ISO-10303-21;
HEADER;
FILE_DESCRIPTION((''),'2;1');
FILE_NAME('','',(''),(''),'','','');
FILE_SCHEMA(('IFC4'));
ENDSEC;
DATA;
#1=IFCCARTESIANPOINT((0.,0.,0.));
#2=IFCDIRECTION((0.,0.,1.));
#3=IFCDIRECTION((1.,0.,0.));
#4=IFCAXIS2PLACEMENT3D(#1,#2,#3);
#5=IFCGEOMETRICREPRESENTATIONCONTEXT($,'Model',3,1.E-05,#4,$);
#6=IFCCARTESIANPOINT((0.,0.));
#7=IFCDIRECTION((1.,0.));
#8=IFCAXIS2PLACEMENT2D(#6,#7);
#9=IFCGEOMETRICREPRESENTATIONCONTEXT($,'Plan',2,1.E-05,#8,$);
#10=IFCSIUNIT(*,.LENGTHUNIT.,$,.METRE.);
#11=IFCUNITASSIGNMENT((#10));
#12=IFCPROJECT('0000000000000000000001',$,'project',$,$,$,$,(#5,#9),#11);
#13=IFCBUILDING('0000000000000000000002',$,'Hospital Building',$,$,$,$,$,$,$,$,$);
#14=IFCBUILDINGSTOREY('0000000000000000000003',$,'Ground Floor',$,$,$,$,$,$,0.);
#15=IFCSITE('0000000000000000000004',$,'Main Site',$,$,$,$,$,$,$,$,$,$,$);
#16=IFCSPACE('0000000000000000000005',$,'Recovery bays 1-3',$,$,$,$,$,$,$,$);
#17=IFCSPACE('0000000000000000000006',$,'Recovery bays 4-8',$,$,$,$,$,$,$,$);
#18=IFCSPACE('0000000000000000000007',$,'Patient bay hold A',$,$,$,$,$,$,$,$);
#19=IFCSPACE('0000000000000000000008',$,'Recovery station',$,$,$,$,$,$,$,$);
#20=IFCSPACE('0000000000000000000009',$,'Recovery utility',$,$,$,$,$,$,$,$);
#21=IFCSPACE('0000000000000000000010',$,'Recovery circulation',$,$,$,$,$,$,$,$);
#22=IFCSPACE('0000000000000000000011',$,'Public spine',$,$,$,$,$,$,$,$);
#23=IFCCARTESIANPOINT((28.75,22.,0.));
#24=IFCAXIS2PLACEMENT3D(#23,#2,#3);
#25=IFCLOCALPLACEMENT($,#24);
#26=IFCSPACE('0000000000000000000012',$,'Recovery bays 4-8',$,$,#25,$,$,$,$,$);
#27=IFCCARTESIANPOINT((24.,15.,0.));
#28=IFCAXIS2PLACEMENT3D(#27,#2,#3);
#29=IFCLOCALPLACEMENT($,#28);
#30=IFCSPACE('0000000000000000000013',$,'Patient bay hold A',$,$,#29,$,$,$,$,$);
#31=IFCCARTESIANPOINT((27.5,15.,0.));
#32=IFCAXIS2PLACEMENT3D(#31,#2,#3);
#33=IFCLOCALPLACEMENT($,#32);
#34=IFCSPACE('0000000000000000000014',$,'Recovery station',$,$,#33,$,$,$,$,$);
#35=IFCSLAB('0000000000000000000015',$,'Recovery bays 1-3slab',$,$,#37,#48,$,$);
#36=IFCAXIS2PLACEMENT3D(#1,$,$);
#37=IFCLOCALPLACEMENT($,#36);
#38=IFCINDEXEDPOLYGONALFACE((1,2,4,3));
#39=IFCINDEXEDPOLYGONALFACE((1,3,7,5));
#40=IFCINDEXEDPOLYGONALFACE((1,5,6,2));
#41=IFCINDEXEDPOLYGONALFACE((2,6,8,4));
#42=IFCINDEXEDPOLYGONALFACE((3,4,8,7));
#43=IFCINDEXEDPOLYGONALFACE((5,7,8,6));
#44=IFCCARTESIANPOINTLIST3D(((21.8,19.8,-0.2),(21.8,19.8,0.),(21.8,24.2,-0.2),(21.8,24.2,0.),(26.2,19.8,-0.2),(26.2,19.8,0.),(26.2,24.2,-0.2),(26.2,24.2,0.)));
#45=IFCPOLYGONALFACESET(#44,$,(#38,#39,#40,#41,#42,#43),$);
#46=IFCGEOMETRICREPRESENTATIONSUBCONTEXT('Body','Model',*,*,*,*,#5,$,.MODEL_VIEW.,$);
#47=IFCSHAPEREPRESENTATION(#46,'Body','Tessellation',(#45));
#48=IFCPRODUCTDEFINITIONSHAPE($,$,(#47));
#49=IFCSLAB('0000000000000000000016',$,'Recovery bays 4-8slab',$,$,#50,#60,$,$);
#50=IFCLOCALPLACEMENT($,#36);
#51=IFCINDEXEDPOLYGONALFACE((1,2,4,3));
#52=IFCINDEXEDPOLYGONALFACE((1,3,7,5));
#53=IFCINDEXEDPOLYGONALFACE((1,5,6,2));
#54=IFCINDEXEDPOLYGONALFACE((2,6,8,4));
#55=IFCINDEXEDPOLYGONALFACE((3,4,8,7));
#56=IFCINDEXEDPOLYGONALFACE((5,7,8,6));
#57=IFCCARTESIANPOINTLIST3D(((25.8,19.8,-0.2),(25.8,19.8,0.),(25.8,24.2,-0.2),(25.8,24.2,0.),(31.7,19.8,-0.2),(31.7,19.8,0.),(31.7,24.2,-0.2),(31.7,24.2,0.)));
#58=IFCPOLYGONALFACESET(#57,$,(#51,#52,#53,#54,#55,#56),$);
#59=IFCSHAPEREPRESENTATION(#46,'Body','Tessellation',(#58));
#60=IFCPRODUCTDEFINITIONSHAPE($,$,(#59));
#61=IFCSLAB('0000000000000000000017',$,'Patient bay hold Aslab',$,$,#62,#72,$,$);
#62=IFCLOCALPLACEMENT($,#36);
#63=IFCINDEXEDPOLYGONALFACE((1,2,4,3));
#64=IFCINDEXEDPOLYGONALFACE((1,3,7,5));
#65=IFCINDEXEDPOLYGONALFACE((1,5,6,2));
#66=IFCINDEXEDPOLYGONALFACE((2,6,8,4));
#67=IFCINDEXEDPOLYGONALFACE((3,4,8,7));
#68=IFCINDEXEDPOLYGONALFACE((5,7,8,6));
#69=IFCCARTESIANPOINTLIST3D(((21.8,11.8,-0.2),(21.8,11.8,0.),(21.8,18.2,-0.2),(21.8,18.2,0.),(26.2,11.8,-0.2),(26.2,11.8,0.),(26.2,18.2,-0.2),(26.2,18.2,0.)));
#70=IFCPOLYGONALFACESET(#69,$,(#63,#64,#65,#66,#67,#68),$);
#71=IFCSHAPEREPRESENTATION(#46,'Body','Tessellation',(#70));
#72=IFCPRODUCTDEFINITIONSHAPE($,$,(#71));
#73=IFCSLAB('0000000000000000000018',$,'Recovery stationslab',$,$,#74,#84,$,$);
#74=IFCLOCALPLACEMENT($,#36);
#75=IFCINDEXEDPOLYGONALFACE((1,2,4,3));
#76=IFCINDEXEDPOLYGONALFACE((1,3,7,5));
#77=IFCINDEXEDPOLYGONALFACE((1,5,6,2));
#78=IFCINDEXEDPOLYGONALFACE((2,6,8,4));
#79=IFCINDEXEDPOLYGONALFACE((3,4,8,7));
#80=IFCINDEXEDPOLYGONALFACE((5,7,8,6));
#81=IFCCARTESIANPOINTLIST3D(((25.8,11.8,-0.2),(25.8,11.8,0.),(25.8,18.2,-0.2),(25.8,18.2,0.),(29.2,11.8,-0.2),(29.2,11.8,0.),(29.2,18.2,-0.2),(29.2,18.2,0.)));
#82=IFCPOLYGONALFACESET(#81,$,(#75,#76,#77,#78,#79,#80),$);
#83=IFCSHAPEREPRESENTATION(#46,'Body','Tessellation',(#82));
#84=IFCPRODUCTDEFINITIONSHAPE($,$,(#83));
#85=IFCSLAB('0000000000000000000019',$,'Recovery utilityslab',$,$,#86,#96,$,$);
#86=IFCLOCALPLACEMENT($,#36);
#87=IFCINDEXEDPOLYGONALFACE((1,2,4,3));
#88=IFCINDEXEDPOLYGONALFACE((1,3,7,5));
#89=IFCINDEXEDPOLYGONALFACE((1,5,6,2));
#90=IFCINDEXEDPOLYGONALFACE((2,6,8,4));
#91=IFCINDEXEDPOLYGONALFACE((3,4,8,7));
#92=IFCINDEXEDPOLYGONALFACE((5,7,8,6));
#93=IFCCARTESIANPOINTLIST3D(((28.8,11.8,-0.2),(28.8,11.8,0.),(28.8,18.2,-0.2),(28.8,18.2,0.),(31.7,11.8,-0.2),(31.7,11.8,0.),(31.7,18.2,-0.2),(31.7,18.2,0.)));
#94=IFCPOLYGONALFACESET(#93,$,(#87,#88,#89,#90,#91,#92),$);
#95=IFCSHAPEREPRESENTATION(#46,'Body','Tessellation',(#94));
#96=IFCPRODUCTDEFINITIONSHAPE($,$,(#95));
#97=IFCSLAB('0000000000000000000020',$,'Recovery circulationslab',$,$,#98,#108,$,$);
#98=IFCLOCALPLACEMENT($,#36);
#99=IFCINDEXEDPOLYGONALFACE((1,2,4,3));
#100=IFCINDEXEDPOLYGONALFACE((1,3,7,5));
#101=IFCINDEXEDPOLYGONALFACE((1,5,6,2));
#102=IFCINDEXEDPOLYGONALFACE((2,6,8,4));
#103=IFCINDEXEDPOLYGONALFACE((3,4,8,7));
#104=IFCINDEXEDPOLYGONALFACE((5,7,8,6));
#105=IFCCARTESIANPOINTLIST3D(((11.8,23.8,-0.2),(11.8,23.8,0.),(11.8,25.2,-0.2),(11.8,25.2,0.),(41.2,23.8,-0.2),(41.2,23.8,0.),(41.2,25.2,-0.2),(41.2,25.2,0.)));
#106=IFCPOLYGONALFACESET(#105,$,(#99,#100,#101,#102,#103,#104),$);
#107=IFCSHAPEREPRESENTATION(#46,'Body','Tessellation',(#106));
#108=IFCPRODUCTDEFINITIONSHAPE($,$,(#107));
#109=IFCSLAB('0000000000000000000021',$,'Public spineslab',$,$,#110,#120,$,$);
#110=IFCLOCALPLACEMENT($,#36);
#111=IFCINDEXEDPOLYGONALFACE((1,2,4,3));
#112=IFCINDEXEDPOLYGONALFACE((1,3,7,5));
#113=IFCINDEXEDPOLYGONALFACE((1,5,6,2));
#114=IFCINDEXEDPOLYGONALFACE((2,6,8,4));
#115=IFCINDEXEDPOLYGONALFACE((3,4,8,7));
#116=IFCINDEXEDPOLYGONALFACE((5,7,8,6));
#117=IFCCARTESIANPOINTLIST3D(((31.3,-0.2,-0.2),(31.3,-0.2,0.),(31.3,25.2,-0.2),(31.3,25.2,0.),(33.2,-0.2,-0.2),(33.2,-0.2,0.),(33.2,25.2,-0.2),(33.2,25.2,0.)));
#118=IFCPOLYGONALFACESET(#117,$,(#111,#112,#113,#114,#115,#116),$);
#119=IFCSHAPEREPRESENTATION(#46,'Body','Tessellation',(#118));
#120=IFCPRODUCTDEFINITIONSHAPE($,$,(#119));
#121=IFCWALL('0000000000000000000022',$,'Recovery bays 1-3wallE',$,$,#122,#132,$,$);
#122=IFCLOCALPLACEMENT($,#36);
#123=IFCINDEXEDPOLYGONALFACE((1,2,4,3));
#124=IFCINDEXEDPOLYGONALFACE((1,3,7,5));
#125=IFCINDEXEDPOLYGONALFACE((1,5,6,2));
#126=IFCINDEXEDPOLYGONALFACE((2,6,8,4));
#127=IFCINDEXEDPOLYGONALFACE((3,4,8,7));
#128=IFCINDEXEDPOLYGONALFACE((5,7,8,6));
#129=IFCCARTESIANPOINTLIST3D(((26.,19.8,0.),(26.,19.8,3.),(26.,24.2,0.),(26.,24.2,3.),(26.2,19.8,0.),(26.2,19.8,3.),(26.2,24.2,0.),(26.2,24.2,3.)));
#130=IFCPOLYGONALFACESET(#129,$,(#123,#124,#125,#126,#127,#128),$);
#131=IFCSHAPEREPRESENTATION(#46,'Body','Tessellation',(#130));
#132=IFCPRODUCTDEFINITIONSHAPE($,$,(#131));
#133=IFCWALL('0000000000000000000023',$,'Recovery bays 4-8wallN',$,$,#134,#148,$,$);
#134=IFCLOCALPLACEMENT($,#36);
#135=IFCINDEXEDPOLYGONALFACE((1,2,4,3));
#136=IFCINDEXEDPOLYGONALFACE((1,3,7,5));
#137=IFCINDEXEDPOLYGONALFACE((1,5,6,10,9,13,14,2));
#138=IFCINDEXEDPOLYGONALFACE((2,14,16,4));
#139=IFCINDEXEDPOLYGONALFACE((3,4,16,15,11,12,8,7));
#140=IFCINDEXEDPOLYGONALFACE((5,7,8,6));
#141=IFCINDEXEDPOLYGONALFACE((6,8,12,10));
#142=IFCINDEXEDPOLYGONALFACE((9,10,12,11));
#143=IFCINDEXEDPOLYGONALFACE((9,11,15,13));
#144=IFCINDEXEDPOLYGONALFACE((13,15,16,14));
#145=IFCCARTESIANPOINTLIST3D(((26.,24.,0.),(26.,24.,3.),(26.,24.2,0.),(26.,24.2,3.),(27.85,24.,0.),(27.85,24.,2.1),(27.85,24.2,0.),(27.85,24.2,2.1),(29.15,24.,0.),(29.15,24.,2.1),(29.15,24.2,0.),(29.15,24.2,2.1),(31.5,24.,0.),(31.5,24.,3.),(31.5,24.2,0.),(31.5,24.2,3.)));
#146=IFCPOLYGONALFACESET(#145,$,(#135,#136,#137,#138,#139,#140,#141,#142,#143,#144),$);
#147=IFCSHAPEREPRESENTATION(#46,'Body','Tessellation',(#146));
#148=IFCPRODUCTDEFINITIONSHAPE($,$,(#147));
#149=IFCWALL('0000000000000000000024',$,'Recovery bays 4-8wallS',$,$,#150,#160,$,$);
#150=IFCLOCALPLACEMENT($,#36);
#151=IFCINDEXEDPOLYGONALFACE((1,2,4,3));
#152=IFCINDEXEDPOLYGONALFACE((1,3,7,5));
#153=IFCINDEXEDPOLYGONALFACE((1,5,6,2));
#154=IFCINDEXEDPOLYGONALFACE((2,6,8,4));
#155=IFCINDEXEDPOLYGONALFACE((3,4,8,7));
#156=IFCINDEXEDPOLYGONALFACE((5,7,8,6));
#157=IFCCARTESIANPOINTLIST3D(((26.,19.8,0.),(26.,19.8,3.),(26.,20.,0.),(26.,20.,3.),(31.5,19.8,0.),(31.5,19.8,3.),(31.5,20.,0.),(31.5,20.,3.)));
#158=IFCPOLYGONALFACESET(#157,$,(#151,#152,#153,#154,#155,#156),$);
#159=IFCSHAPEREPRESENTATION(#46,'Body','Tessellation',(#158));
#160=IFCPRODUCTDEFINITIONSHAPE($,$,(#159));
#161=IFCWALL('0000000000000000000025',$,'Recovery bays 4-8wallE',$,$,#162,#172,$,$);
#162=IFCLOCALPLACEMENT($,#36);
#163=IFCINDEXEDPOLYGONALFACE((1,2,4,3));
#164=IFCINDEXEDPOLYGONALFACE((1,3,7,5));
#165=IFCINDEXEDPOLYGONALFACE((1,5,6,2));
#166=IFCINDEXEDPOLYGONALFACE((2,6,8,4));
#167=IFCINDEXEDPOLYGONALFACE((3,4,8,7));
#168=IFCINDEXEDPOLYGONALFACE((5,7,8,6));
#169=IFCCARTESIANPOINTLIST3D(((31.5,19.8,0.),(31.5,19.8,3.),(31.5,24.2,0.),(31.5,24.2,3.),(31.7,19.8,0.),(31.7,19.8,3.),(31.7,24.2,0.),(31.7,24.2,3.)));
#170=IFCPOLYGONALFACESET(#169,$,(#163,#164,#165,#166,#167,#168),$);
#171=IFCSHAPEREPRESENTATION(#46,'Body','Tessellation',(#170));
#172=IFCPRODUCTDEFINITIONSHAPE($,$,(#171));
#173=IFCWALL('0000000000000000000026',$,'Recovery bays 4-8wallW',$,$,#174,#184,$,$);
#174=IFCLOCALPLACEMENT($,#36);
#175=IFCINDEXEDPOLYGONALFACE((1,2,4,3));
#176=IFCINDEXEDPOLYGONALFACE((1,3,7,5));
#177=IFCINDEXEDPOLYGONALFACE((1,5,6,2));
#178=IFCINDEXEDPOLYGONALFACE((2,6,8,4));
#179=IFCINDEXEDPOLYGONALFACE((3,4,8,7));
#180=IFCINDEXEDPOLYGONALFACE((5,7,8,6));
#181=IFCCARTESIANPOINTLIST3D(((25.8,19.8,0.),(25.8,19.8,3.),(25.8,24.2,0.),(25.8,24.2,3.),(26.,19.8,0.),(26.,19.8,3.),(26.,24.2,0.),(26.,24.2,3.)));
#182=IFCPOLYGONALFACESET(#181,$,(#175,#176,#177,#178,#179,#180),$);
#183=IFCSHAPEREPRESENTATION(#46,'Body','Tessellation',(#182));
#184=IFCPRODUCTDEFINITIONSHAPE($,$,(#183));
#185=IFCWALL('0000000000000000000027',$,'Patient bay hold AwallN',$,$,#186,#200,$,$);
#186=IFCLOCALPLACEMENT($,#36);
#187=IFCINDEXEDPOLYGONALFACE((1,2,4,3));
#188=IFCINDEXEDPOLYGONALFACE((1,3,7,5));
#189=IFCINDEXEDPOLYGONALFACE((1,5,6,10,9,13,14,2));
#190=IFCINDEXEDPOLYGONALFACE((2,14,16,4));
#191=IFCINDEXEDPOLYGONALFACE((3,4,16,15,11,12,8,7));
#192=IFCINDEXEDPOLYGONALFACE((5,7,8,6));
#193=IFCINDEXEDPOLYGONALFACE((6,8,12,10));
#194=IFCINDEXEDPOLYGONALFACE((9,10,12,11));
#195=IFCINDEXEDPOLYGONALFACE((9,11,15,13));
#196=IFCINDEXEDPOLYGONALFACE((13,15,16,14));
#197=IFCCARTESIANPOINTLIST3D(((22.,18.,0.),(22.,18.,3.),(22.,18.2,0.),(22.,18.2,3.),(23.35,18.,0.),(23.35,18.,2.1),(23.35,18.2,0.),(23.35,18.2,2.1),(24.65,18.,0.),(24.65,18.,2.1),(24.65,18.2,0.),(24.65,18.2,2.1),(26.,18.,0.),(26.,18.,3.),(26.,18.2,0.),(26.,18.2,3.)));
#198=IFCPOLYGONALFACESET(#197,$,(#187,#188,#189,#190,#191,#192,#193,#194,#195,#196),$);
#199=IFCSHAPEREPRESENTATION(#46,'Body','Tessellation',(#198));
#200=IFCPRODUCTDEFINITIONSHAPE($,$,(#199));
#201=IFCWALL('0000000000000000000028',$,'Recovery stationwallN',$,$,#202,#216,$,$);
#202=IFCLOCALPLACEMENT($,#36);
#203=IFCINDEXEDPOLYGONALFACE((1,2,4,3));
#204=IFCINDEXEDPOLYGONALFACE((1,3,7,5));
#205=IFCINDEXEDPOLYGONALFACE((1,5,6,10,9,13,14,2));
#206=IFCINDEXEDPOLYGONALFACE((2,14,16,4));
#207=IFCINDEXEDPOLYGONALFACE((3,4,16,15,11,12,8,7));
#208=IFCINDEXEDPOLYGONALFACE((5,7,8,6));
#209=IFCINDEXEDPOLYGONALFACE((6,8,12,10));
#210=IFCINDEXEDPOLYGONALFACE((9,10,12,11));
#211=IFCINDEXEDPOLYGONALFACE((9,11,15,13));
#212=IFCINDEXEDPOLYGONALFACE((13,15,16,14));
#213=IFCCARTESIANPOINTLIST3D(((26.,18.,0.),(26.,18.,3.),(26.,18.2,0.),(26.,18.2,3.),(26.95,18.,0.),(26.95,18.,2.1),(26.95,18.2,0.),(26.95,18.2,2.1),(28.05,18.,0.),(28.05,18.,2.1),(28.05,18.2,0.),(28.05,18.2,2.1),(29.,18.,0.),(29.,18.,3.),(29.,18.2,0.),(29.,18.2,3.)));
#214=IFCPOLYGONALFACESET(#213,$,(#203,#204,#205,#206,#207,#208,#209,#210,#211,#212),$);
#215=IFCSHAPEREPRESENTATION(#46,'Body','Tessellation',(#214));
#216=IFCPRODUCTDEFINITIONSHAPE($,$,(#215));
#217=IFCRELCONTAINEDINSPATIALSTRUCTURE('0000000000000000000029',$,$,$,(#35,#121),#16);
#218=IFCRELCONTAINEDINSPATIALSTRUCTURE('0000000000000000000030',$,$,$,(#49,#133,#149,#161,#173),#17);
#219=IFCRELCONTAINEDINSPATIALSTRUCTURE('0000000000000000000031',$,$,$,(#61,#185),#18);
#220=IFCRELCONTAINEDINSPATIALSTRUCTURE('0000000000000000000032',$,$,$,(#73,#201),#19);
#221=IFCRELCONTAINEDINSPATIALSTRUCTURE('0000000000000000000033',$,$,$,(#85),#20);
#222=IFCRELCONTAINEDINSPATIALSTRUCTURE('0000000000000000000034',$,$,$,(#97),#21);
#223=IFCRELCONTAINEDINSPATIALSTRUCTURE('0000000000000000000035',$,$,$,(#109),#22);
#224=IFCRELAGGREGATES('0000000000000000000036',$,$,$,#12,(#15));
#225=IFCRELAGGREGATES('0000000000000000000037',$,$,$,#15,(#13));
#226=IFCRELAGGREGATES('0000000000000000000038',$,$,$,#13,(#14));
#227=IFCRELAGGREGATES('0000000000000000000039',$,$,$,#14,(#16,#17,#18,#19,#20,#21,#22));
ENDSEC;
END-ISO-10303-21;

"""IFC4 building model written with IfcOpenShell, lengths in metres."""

from ifc_helpers import new_model, si_unit, frame, origin_with_axes, origin_2d_with_axis, place, context, subcontext, project, spatial, indexed_curve, rectangle, outline, extrude, element, save


model = new_model("IFC4")

# Units and contexts
model_context = context("Model", 3, precision=1e-05, world=origin_with_axes())
plan_context = context("Plan", 2, precision=1e-05, world=origin_2d_with_axis())
body_context = subcontext(model_context, "Body", "Model", "MODEL_VIEW")
ifc_project = project(units=[si_unit("LENGTHUNIT", "METRE")], contexts=[model_context, plan_context])

# Site, building, storey, space
site = spatial("IfcSite", under=ifc_project, Name="Main Site")
building = spatial("IfcBuilding", under=site, Name="Hospital Building")
storey = spatial("IfcBuildingStorey", under=building, Name="Ground Floor", Elevation=0.0)
space_1 = spatial("IfcSpace", under=storey, Name="Recovery bays 1-3")

# Slab
slab_1_placement = place(None, frame((24.0, 22.0, -0.2), z_axis=(0.0, 0.0, 1.0), x_axis=(1.0, 0.0, 0.0)))
element("IfcSlab", 1, at=slab_1_placement, inside=space_1, Name="Recovery bays 1-3slab", context=body_context, shape_type="SweptSolid", body=[
    extrude(rectangle(XDim=4.4, YDim=4.4), origin_with_axes(), (0.0, 0.0, 1.0), 0.2),
])

# Shared definitions
space_2 = spatial("IfcSpace", under=storey, Name="Recovery bays 4-8")

# Slab
slab_2_placement = place(None, frame((28.75, 22.0, -0.2), z_axis=(0.0, 0.0, 1.0), x_axis=(1.0, 0.0, 0.0)))
element("IfcSlab", 2, at=slab_2_placement, inside=space_2, Name="Recovery bays 4-8slab", context=body_context, shape_type="SweptSolid", body=[
    extrude(rectangle(XDim=5.9, YDim=4.4), origin_with_axes(), (0.0, 0.0, 1.0), 0.2),
])

# Shared definitions
space_3 = spatial("IfcSpace", under=storey, Name="Patient bay hold A")

# Slab
slab_3_placement = place(None, frame((24.0, 15.0, -0.2), z_axis=(0.0, 0.0, 1.0), x_axis=(1.0, 0.0, 0.0)))
element("IfcSlab", 3, at=slab_3_placement, inside=space_3, Name="Patient bay hold Aslab", context=body_context, shape_type="SweptSolid", body=[
    extrude(rectangle(XDim=4.4, YDim=6.4), origin_with_axes(), (0.0, 0.0, 1.0), 0.2),
])

# Shared definitions
space_4 = spatial("IfcSpace", under=storey, Name="Recovery station")

# Slab
slab_4_placement = place(None, frame((27.5, 15.0, -0.2), z_axis=(0.0, 0.0, 1.0), x_axis=(1.0, 0.0, 0.0)))
element("IfcSlab", 4, at=slab_4_placement, inside=space_4, Name="Recovery stationslab", context=body_context, shape_type="SweptSolid", body=[
    extrude(rectangle(XDim=3.4, YDim=6.4), origin_with_axes(), (0.0, 0.0, 1.0), 0.2),
])

# Shared definitions
space_5 = spatial("IfcSpace", under=storey, Name="Recovery utility")

# Slab
slab_5_placement = place(None, frame((30.25, 15.0, -0.2), z_axis=(0.0, 0.0, 1.0), x_axis=(1.0, 0.0, 0.0)))
element("IfcSlab", 5, at=slab_5_placement, inside=space_5, Name="Recovery utilityslab", context=body_context, shape_type="SweptSolid", body=[
    extrude(rectangle(XDim=2.9, YDim=6.4), origin_with_axes(), (0.0, 0.0, 1.0), 0.2),
])

# Shared definitions
space_6 = spatial("IfcSpace", under=storey, Name="Recovery circulation")

# Slab
slab_6_placement = place(None, frame((26.5, 24.5, -0.2), z_axis=(0.0, 0.0, 1.0), x_axis=(1.0, 0.0, 0.0)))
element("IfcSlab", 6, at=slab_6_placement, inside=space_6, Name="Recovery circulationslab", context=body_context, shape_type="SweptSolid", body=[
    extrude(rectangle(XDim=29.4, YDim=1.4), origin_with_axes(), (0.0, 0.0, 1.0), 0.2),
])

# Shared definitions
space_7 = spatial("IfcSpace", under=storey, Name="Public spine")

# Slab
slab_7_placement = place(None, frame((32.25, 12.5, -0.2), z_axis=(0.0, 0.0, 1.0), x_axis=(1.0, 0.0, 0.0)))
element("IfcSlab", 7, at=slab_7_placement, inside=space_7, Name="Public spineslab", context=body_context, shape_type="SweptSolid", body=[
    extrude(rectangle(XDim=1.9, YDim=25.4), origin_with_axes(), (0.0, 0.0, 1.0), 0.2),
])

# Walls
wall_1_placement = place(None, frame((26.2, 19.8, 0.0), z_axis=(0.0, 0.0, 1.0), x_axis=(0.0, 1.0, 0.0)))
element("IfcWall", 8, at=wall_1_placement, inside=space_1, Name="Recovery bays 1-3wallE", context=body_context, shape_type="SweptSolid", body=[
    extrude(outline(indexed_curve([(0.0, 0.0), (0.0, 0.2), (4.4, 0.2), (4.4, 0.0), (0.0, 0.0)], self_intersect=False)), origin_with_axes(), (0.0, 0.0, 1.0), 3.0),
])
wall_2_placement = place(None, frame((26.0, 24.0, 0.0), z_axis=(0.0, 0.0, 1.0), x_axis=(1.0, 0.0, 0.0)))
wall_2 = element("IfcWall", 9, at=wall_2_placement, inside=space_2, Name="Recovery bays 4-8wallN", context=body_context, shape_type="SweptSolid", body=[
    extrude(outline(indexed_curve([(0.0, 0.0), (0.0, 0.2), (5.5, 0.2), (5.5, 0.0), (0.0, 0.0)], self_intersect=False)), origin_with_axes(), (0.0, 0.0, 1.0), 3.0),
])

# Shared definitions
space_8_placement = place(None, frame((28.75, 22.0, 0.0), z_axis=(0.0, 0.0, 1.0), x_axis=(1.0, 0.0, 0.0)))
space_8 = spatial("IfcSpace", at=space_8_placement, Name="Recovery bays 4-8")

# Opening
opening_1_placement = place(wall_2_placement, frame((1.85, -0.1, 0.0), z_axis=(0.0, 0.0, 1.0), x_axis=(1.0, 0.0, 0.0)))
element("IfcOpeningElement", 10, at=opening_1_placement, inside=space_8, cuts=wall_2, context=body_context, shape_type="SweptSolid", body=[
    extrude(outline(indexed_curve([(0.0, 0.0), (0.0, 0.4), (1.3, 0.4), (1.3, 0.0), (0.0, 0.0)], self_intersect=False)), origin_with_axes(), (0.0, 0.0, 1.0), 2.1),
])

# Walls
wall_3_placement = place(None, frame((26.0, 19.8, 0.0), z_axis=(0.0, 0.0, 1.0), x_axis=(1.0, 0.0, 0.0)))
element("IfcWall", 11, at=wall_3_placement, inside=space_2, Name="Recovery bays 4-8wallS", context=body_context, shape_type="SweptSolid", body=[
    extrude(outline(indexed_curve([(0.0, 0.0), (0.0, 0.2), (5.5, 0.2), (5.5, 0.0), (0.0, 0.0)], self_intersect=False)), origin_with_axes(), (0.0, 0.0, 1.0), 3.0),
])
for number, where, z_axis, x_axis, name in (
    (12, (31.7, 19.8, 0.0), (0.0, 0.0, 1.0), (0.0, 1.0, 0.0), "Recovery bays 4-8wallE"),
    (13, (26.0, 19.8, 0.0), (0.0, 0.0, 1.0), (0.0, 1.0, 0.0), "Recovery bays 4-8wallW"),
):
    element("IfcWall", number, at=place(None, frame(where, z_axis=z_axis, x_axis=x_axis)), inside=space_2, Name=name, context=body_context, shape_type="SweptSolid", body=[
        extrude(outline(indexed_curve([(0.0, 0.0), (0.0, 0.2), (4.4, 0.2), (4.4, 0.0), (0.0, 0.0)], self_intersect=False)), origin_with_axes(), (0.0, 0.0, 1.0), 3.0),
    ])

# Wall
wall_4_placement = place(None, frame((22.0, 18.0, 0.0), z_axis=(0.0, 0.0, 1.0), x_axis=(1.0, 0.0, 0.0)))
wall_4 = element("IfcWall", 14, at=wall_4_placement, inside=space_3, Name="Patient bay hold AwallN", context=body_context, shape_type="SweptSolid", body=[
    extrude(outline(indexed_curve([(0.0, 0.0), (0.0, 0.2), (4.0, 0.2), (4.0, 0.0), (0.0, 0.0)], self_intersect=False)), origin_with_axes(), (0.0, 0.0, 1.0), 3.0),
])

# Shared definitions
space_9_placement = place(None, frame((24.0, 15.0, 0.0), z_axis=(0.0, 0.0, 1.0), x_axis=(1.0, 0.0, 0.0)))
space_9 = spatial("IfcSpace", at=space_9_placement, Name="Patient bay hold A")

# Opening
opening_2_placement = place(wall_4_placement, frame((1.35, -0.1, 0.0), z_axis=(0.0, 0.0, 1.0), x_axis=(1.0, 0.0, 0.0)))
element("IfcOpeningElement", 15, at=opening_2_placement, inside=space_9, cuts=wall_4, context=body_context, shape_type="SweptSolid", body=[
    extrude(outline(indexed_curve([(0.0, 0.0), (0.0, 0.4), (1.3, 0.4), (1.3, 0.0), (0.0, 0.0)], self_intersect=False)), origin_with_axes(), (0.0, 0.0, 1.0), 2.1),
])

# Wall
wall_5_placement = place(None, frame((26.0, 18.0, 0.0), z_axis=(0.0, 0.0, 1.0), x_axis=(1.0, 0.0, 0.0)))
wall_5 = element("IfcWall", 16, at=wall_5_placement, inside=space_4, Name="Recovery stationwallN", context=body_context, shape_type="SweptSolid", body=[
    extrude(outline(indexed_curve([(0.0, 0.0), (0.0, 0.2), (3.0, 0.2), (3.0, 0.0), (0.0, 0.0)], self_intersect=False)), origin_with_axes(), (0.0, 0.0, 1.0), 3.0),
])

# Shared definitions
space_10_placement = place(None, frame((27.5, 15.0, 0.0), z_axis=(0.0, 0.0, 1.0), x_axis=(1.0, 0.0, 0.0)))
space_10 = spatial("IfcSpace", at=space_10_placement, Name="Recovery station")

# Opening
opening_3_placement = place(wall_5_placement, frame((0.95, -0.1, 0.0), z_axis=(0.0, 0.0, 1.0), x_axis=(1.0, 0.0, 0.0)))
element("IfcOpeningElement", 17, at=opening_3_placement, inside=space_10, cuts=wall_5, context=body_context, shape_type="SweptSolid", body=[
    extrude(outline(indexed_curve([(0.0, 0.0), (0.0, 0.4), (1.1, 0.4), (1.1, 0.0), (0.0, 0.0)], self_intersect=False)), origin_with_axes(), (0.0, 0.0, 1.0), 2.1),
])

save(model, "model.ifc")
